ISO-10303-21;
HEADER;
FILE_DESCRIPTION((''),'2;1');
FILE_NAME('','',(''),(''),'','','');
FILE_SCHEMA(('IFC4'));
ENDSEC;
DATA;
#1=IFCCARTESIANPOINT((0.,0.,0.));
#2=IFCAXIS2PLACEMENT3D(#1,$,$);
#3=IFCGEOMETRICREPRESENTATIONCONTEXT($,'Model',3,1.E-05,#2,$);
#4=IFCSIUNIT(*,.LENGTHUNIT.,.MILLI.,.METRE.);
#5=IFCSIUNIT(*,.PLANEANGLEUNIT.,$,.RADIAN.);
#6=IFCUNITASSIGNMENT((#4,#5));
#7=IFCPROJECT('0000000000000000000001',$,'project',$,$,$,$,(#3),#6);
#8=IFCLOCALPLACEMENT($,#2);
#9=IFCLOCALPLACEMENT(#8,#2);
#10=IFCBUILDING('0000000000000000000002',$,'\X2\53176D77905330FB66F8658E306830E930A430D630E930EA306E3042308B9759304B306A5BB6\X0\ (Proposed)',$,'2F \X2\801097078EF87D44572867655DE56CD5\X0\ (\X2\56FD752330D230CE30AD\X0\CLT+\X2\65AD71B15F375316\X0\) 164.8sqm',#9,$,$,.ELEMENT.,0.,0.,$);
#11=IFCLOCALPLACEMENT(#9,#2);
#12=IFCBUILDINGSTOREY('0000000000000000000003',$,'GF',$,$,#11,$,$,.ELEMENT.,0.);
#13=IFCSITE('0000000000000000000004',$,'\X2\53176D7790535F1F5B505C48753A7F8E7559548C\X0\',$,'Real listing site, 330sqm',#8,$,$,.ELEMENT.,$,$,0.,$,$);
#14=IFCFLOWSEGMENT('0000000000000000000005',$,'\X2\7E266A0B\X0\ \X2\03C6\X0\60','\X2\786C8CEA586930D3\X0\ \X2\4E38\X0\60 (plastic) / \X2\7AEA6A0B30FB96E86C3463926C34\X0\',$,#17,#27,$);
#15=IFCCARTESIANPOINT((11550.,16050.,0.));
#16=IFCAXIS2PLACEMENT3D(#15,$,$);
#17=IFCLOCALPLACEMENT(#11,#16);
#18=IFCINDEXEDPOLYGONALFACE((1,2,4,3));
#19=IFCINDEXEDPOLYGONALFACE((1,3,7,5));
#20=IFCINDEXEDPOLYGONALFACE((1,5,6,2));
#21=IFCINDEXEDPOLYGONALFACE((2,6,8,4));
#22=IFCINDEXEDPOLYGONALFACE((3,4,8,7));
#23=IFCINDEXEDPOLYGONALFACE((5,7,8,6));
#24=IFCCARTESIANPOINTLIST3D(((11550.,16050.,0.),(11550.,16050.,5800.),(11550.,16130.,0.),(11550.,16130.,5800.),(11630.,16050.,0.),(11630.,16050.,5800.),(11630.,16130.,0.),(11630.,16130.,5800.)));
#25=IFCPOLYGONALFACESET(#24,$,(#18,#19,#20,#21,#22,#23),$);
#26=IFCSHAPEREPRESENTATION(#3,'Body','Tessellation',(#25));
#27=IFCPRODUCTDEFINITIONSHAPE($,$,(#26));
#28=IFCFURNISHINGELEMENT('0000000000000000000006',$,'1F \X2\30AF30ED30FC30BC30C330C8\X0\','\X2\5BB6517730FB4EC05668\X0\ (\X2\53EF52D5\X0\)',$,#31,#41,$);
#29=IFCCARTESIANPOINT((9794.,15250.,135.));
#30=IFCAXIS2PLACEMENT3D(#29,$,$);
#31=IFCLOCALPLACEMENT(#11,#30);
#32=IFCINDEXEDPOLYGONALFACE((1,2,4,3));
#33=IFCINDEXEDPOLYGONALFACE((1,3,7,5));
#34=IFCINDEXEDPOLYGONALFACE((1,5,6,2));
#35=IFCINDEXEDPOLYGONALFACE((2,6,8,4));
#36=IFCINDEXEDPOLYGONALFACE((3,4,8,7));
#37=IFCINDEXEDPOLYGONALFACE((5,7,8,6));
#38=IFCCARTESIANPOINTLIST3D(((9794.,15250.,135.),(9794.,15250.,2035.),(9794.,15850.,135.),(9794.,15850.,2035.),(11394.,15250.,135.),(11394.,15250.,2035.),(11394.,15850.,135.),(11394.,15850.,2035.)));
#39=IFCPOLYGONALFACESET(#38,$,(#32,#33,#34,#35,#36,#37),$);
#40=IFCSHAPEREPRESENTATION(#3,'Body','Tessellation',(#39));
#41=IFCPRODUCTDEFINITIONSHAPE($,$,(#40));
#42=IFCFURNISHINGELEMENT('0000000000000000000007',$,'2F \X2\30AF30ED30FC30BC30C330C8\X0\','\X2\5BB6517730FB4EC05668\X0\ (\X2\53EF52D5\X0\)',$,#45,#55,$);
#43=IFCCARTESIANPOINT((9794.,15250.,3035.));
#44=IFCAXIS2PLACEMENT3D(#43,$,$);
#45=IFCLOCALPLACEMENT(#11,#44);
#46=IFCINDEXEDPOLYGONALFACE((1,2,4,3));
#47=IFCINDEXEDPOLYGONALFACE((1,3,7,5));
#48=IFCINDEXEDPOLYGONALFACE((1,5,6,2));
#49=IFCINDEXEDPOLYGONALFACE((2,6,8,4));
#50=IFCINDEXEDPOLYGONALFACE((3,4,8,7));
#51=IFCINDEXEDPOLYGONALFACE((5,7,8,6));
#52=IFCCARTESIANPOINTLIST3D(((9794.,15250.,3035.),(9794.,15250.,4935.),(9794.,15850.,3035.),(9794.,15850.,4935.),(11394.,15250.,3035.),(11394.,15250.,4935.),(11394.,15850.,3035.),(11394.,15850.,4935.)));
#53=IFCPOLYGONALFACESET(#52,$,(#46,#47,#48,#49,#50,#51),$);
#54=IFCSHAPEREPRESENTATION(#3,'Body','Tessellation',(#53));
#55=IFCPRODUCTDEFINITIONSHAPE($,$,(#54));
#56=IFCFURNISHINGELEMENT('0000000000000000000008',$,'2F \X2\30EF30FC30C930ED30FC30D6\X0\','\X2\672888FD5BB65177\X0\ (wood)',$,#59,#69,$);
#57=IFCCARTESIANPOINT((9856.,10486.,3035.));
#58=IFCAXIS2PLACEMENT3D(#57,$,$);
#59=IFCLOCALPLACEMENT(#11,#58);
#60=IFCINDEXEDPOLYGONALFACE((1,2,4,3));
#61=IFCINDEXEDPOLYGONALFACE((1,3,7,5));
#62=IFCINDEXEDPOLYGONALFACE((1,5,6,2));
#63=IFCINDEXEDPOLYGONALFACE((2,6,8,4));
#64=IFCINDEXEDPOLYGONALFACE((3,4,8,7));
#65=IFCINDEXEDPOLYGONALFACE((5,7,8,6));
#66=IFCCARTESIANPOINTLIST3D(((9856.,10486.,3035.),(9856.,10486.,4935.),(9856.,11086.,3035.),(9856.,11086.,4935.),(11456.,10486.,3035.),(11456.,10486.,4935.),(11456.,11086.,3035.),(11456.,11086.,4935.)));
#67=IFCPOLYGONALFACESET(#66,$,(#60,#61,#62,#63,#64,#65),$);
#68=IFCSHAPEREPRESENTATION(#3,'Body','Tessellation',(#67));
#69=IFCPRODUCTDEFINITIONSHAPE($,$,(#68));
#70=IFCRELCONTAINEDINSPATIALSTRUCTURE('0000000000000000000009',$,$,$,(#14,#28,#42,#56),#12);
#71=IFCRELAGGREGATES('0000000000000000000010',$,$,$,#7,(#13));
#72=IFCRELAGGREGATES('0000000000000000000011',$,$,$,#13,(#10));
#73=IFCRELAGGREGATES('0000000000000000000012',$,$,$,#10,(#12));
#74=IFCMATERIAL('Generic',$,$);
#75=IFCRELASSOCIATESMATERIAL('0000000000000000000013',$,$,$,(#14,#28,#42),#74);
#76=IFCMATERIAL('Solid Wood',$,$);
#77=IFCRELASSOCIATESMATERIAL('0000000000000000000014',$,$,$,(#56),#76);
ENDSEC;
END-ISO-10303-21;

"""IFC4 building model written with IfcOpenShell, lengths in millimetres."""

from ifc_helpers import new_model, si_unit, frame, frame_2d, origin, place, context, project, spatial, rectangle, extrude, material, element, save


model = new_model("IFC4")

# Units and contexts
model_context = context("Model", 3, precision=1e-05, world=origin())
ifc_project = project(units=[si_unit("LENGTHUNIT", "METRE", prefix="MILLI"), si_unit("PLANEANGLEUNIT", "RADIAN")], contexts=[model_context])

# Site, building, storey
site_placement = place(None, origin())
site = spatial("IfcSite", under=ifc_project, at=site_placement, Name="北海道弟子屈町美留和", ObjectType="Real listing site, 330sqm", CompositionType="ELEMENT", RefElevation=0.0)
building_placement = place(site_placement, origin())
building = spatial("IfcBuilding", under=site, at=building_placement, Name="北海道・書斎とライブラリのある静かな家 (Proposed)", ObjectType="2F 耐震軸組在来工法 (国産ヒノキCLT+断熱強化) 164.8sqm", CompositionType="ELEMENT", ElevationOfRefHeight=0.0, ElevationOfTerrain=0.0)
storey_placement = place(building_placement, origin())
storey = spatial("IfcBuildingStorey", under=building, at=storey_placement, Name="GF", CompositionType="ELEMENT", Elevation=0.0)

# Shared definitions
ifc_material_1 = material(Name="Solid Wood")

# Shared definitions
ifc_material_2 = material(Name="Generic")

# Flow segment
flow_segment_placement = place(storey_placement, frame((11550.0, 16050.0, 0.0)))
element("IfcFlowSegment", 1, at=flow_segment_placement, inside=storey, material=ifc_material_2, Name="縦樋 φ60", Description="硬質塩ビ 丸60 (plastic) / 竪樋・雨水排水", context=model_context, shape_type="SweptSolid", body=[
    extrude(rectangle(XDim=80.0, YDim=80.0, at=frame_2d((40.0, 40.0))), frame((11550.0, 16050.0, 0.0)), (0.0, 0.0, 1.0), 5800.0),
])

# Furnishing elements
furnishing_1_placement = place(storey_placement, frame((9794.0, 15250.0, 135.0)))
element("IfcFurnishingElement", 2, at=furnishing_1_placement, inside=storey, material=ifc_material_2, Name="1F クローゼット", Description="家具・什器 (可動)", context=model_context, shape_type="SweptSolid", body=[
    extrude(rectangle(XDim=1600.0, YDim=600.0, at=frame_2d((800.0, 300.0))), frame((9794.0, 15250.0, 135.0)), (0.0, 0.0, 1.0), 1900.0),
])
furnishing_2_placement = place(storey_placement, frame((9794.0, 15250.0, 3035.0)))
element("IfcFurnishingElement", 3, at=furnishing_2_placement, inside=storey, material=ifc_material_2, Name="2F クローゼット", Description="家具・什器 (可動)", context=model_context, shape_type="SweptSolid", body=[
    extrude(rectangle(XDim=1600.0, YDim=600.0, at=frame_2d((800.0, 300.0))), frame((9794.0, 15250.0, 3035.0)), (0.0, 0.0, 1.0), 1900.0),
])
furnishing_3_placement = place(storey_placement, frame((9856.0, 10486.0, 3035.0)))
element("IfcFurnishingElement", 4, at=furnishing_3_placement, inside=storey, material=ifc_material_1, Name="2F ワードローブ", Description="木製家具 (wood)", context=model_context, shape_type="SweptSolid", body=[
    extrude(rectangle(XDim=1600.0, YDim=600.0, at=frame_2d((800.0, 300.0))), frame((9856.0, 10486.0, 3035.0)), (0.0, 0.0, 1.0), 1900.0),
])

save(model, "model.ifc")
